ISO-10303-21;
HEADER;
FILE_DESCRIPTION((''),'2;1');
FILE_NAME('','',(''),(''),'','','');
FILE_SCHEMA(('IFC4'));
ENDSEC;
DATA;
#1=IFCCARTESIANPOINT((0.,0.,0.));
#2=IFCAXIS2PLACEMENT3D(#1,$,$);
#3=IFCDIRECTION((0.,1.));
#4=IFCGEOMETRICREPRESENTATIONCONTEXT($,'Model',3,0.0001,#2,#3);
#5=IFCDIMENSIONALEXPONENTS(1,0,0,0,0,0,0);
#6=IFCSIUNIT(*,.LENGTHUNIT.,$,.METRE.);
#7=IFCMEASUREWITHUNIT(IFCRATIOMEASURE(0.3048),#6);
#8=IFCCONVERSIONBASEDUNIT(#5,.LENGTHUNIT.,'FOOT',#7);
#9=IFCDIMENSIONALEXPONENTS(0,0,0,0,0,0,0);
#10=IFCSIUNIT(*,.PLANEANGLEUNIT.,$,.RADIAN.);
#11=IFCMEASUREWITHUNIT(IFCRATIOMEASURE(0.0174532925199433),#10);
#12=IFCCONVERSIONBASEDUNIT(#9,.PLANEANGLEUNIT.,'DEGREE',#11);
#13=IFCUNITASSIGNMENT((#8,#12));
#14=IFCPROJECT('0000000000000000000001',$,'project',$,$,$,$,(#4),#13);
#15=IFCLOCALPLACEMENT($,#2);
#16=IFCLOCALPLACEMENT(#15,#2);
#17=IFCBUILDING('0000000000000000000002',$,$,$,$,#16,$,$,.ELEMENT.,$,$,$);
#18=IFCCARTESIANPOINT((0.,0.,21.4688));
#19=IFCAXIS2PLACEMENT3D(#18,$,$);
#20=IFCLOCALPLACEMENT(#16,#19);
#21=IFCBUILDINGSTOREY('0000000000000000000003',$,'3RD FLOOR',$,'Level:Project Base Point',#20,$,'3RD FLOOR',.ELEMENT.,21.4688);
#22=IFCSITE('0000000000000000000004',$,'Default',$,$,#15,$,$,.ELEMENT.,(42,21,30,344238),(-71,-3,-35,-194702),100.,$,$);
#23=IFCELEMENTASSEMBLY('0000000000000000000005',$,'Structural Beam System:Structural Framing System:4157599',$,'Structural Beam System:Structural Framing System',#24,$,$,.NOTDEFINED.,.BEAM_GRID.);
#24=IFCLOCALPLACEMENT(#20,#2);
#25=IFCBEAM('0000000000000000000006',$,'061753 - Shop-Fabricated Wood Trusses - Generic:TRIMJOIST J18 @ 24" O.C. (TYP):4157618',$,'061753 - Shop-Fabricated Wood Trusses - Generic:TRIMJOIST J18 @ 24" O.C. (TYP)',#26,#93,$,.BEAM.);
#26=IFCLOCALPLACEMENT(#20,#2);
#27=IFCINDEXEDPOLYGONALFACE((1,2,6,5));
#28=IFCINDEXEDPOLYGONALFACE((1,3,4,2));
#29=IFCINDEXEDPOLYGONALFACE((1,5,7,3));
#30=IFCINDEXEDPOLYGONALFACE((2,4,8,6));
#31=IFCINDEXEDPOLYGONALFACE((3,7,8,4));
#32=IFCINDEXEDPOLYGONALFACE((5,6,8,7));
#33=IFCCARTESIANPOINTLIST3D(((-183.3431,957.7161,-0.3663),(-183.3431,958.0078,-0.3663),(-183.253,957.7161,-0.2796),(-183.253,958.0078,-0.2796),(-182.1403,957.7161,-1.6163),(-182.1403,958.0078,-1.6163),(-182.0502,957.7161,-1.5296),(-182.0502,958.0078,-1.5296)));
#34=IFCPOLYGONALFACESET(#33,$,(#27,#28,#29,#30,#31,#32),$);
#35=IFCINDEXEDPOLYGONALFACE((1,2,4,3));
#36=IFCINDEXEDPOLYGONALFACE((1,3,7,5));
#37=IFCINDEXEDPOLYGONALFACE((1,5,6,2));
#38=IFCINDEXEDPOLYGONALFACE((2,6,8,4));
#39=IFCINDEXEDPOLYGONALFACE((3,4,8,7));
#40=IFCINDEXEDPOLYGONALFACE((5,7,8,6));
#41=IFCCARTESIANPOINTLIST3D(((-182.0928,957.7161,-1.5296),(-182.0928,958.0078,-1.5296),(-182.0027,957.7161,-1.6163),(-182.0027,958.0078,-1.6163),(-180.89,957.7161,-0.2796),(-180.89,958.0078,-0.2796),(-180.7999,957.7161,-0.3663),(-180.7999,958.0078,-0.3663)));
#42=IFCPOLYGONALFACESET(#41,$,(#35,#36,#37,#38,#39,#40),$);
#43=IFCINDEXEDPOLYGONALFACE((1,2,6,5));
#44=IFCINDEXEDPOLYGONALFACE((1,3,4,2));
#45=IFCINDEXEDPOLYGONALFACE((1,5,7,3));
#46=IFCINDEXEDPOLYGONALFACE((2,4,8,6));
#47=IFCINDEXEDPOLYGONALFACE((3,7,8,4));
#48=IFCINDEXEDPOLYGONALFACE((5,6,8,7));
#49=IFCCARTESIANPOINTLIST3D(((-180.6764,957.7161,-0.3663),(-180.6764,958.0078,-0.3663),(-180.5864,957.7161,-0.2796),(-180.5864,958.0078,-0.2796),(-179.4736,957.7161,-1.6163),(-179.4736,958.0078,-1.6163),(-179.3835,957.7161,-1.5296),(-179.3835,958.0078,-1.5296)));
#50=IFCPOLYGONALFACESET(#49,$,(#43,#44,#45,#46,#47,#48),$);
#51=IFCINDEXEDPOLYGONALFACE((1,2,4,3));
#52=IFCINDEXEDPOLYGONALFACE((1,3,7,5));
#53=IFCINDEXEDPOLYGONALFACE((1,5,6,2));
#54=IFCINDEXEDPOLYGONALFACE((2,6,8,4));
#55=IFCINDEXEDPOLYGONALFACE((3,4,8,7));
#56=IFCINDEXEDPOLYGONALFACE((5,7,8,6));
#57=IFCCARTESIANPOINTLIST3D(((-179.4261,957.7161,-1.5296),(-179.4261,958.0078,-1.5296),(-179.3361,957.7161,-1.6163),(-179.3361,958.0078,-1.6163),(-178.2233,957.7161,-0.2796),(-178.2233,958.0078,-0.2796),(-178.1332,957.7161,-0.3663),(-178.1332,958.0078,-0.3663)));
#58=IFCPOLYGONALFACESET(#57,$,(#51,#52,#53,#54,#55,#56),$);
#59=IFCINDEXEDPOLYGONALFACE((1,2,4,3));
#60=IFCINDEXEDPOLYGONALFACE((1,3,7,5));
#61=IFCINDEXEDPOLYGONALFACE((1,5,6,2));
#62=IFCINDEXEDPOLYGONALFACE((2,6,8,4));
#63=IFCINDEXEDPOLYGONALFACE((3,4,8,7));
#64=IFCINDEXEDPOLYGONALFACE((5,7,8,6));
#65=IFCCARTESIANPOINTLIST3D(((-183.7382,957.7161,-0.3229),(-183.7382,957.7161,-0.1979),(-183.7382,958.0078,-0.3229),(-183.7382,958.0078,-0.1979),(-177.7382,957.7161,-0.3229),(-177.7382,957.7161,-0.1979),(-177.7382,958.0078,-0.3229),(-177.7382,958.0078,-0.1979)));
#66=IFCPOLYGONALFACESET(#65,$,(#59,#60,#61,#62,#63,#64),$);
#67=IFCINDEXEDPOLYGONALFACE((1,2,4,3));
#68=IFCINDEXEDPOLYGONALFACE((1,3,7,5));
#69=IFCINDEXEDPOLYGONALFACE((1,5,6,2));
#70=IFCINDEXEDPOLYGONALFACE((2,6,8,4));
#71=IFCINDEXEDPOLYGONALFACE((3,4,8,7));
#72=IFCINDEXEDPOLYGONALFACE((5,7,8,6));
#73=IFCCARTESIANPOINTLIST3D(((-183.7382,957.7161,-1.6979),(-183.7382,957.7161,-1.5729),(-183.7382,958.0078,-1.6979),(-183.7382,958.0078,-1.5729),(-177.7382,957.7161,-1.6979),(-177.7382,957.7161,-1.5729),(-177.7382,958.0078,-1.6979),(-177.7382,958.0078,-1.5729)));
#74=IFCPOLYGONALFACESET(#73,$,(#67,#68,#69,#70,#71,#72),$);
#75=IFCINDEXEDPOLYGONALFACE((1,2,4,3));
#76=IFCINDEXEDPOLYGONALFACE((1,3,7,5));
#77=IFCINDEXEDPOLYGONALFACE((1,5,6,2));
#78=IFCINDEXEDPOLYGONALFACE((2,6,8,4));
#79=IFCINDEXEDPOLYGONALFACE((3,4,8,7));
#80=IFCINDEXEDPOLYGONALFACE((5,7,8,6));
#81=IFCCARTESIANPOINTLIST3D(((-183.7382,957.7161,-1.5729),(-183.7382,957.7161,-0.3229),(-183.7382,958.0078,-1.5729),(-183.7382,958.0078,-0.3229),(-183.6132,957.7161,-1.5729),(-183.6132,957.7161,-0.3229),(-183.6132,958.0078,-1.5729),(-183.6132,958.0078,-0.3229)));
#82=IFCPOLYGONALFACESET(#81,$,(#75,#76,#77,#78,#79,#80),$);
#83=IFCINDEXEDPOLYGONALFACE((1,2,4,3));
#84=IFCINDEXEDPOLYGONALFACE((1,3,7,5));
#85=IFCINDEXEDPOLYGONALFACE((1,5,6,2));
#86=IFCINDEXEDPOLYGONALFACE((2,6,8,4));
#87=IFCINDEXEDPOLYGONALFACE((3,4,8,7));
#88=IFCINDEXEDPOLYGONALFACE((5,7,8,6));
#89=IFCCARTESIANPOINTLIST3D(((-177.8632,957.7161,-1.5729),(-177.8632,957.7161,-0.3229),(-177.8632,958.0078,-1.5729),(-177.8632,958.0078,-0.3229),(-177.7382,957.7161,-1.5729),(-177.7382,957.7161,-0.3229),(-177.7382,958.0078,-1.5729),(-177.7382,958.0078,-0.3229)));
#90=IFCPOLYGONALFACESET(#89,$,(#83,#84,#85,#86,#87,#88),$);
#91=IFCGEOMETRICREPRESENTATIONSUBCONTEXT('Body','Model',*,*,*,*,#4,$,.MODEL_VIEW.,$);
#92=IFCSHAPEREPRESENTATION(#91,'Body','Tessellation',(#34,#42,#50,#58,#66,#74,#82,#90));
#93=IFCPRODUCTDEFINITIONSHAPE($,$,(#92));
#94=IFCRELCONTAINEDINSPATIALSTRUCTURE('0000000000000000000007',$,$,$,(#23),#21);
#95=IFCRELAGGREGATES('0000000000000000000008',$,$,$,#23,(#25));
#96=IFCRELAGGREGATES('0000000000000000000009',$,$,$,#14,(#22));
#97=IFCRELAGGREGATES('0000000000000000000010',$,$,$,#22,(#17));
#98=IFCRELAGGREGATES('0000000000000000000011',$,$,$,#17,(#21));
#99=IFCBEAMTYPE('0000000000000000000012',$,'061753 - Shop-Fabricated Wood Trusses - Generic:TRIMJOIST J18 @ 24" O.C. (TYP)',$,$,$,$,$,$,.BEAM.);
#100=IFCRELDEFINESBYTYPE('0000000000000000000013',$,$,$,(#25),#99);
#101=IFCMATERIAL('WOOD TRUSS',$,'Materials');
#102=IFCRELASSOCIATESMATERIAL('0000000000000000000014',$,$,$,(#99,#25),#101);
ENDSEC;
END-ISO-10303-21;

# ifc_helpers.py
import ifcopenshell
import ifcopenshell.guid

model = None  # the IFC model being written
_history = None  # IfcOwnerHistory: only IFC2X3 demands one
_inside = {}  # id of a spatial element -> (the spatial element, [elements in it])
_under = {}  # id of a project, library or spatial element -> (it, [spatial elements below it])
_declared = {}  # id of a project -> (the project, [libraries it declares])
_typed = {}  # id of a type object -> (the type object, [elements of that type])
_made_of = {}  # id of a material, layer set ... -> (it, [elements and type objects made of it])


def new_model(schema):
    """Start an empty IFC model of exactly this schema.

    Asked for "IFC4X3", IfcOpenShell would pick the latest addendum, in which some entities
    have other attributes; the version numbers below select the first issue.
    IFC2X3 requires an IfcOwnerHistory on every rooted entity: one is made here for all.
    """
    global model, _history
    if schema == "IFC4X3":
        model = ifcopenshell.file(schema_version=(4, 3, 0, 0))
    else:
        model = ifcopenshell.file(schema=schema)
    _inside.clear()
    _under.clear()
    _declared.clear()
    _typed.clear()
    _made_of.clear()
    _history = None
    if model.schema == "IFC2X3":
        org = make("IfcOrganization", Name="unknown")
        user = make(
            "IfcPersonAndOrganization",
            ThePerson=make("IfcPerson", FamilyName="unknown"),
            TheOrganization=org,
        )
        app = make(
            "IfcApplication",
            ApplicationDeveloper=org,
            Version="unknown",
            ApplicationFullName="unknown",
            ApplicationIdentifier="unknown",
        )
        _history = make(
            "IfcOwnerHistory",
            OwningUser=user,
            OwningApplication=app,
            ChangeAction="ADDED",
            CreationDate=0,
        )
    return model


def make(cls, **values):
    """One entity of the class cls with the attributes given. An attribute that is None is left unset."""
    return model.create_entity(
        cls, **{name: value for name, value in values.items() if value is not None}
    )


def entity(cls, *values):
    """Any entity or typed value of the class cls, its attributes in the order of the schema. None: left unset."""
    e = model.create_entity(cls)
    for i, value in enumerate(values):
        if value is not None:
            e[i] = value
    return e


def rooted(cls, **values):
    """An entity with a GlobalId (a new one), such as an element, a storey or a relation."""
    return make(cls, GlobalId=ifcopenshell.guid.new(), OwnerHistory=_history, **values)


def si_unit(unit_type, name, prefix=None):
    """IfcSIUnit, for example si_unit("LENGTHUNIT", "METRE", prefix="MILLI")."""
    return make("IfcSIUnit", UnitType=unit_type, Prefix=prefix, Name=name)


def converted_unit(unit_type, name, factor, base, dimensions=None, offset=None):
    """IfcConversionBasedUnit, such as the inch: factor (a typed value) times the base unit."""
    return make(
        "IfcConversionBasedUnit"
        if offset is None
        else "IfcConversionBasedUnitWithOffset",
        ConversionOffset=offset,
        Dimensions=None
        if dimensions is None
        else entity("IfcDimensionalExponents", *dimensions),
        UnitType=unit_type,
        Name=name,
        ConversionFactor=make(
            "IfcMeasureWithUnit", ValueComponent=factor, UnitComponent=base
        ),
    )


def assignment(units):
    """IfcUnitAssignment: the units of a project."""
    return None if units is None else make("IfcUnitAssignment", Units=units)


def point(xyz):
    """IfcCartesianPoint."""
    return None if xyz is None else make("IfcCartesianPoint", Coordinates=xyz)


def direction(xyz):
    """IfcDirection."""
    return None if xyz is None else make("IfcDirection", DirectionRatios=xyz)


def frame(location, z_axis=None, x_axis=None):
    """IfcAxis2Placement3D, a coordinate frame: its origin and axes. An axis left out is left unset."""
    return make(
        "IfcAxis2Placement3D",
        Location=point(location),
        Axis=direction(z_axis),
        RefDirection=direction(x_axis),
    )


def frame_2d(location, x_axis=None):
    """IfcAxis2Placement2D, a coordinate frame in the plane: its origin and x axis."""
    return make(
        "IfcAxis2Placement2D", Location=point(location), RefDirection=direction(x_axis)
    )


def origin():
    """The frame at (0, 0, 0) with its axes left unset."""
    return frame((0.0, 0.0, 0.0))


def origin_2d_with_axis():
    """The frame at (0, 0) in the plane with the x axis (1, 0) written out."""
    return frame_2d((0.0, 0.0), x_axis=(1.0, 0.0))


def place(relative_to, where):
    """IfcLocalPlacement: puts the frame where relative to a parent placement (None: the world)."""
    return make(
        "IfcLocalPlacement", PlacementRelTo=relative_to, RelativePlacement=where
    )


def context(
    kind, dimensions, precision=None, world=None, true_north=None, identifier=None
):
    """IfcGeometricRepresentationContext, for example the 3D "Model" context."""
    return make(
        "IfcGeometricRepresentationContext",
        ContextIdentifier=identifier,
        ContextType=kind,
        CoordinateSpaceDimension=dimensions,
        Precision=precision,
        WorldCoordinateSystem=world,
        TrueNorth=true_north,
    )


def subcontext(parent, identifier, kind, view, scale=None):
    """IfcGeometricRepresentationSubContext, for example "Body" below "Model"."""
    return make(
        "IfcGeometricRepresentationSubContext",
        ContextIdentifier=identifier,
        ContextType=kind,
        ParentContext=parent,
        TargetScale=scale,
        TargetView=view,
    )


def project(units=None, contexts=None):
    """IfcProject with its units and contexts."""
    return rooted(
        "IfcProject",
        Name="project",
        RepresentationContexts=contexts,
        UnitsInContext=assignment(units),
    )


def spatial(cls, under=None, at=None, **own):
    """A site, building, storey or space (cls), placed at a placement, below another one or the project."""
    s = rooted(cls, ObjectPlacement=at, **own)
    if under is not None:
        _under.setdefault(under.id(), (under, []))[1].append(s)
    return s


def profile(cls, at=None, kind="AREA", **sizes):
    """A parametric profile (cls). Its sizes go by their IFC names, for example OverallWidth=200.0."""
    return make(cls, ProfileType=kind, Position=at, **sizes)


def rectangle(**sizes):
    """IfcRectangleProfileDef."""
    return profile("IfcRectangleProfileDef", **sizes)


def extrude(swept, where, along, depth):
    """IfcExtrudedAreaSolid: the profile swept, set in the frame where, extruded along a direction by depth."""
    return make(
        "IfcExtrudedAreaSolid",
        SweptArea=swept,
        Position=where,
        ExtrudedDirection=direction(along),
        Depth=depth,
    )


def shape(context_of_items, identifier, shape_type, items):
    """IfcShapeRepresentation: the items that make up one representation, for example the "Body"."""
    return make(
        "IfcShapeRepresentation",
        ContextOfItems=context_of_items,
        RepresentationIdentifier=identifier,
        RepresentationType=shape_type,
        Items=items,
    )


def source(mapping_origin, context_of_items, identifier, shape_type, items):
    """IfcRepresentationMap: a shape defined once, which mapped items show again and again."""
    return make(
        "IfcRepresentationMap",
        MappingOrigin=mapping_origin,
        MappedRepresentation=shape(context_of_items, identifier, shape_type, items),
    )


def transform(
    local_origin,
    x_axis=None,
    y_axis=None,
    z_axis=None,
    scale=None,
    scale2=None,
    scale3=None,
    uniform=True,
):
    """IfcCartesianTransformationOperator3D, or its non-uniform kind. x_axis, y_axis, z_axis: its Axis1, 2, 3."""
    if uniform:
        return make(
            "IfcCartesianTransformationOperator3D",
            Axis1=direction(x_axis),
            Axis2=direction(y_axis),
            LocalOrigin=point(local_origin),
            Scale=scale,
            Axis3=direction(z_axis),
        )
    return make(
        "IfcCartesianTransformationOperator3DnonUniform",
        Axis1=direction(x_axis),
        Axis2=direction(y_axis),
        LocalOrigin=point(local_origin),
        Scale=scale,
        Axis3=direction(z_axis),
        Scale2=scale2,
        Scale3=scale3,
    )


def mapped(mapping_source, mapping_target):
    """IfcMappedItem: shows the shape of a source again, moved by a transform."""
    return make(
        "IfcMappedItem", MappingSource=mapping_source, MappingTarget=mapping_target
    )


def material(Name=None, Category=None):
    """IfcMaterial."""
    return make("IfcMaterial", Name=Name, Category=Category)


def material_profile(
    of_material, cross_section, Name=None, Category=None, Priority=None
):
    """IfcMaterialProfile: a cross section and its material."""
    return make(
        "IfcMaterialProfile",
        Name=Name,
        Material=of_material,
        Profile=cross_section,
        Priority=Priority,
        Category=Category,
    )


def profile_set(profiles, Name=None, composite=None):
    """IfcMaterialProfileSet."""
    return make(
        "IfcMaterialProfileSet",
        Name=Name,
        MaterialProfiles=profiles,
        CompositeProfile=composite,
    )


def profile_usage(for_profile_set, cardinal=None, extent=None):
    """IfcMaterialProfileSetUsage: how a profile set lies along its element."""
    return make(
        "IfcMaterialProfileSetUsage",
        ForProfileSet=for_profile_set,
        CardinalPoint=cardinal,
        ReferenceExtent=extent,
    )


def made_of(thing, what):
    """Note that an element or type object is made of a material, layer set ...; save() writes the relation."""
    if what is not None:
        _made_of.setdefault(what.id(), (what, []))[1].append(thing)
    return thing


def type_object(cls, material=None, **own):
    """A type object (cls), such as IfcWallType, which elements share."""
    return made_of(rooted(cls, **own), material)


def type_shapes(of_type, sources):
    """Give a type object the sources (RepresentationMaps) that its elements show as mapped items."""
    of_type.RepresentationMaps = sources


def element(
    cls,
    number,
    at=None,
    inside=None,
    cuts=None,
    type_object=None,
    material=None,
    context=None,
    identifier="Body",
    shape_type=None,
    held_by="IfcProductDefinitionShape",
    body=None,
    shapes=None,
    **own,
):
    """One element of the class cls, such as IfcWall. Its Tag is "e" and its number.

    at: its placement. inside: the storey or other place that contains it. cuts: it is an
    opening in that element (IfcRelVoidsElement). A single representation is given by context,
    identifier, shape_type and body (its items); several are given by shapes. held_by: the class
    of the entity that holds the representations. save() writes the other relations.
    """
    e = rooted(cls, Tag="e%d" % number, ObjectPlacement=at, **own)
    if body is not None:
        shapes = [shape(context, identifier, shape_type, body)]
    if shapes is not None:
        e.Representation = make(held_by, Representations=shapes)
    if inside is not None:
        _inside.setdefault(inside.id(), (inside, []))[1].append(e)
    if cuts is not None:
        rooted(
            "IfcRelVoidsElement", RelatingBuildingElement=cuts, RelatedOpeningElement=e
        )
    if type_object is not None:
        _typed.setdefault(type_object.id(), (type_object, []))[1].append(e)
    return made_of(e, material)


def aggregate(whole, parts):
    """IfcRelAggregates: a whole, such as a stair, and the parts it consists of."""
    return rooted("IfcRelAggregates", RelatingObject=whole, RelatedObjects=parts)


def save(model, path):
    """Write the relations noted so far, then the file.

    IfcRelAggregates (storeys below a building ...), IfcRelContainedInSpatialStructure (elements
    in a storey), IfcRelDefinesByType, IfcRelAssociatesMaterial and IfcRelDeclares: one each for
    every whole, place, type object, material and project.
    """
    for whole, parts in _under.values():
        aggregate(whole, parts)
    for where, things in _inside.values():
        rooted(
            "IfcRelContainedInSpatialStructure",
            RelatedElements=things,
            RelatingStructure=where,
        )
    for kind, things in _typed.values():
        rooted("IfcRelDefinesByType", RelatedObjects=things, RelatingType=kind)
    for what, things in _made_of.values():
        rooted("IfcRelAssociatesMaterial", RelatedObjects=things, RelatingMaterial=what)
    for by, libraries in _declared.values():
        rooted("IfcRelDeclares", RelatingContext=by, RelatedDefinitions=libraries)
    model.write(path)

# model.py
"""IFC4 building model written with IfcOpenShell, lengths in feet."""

from ifc_helpers import new_model, entity, si_unit, converted_unit, direction, frame, frame_2d, origin, origin_2d_with_axis, place, context, subcontext, project, spatial, rectangle, extrude, source, transform, mapped, material, material_profile, profile_set, profile_usage, type_object, type_shapes, element, aggregate, save


model = new_model("IFC4")

# Units and contexts
model_context = context("Model", 3, precision=0.0001, world=origin(), true_north=direction((0.0, 1.0)))
body_context = subcontext(model_context, "Body", "Model", "MODEL_VIEW")
ifc_project = project(units=[converted_unit("LENGTHUNIT", "FOOT", entity("IfcRatioMeasure", 0.3048), si_unit("LENGTHUNIT", "METRE"), dimensions=[1, 0, 0, 0, 0, 0, 0]), converted_unit("PLANEANGLEUNIT", "DEGREE", entity("IfcRatioMeasure", 0.0174532925199433), si_unit("PLANEANGLEUNIT", "RADIAN"), dimensions=[0, 0, 0, 0, 0, 0, 0])], contexts=[model_context])

# Site, building, storey
site_placement = place(None, origin())
site = spatial("IfcSite", under=ifc_project, at=site_placement, Name="Default", CompositionType="ELEMENT", RefLatitude=(42, 21, 30, 344238), RefLongitude=(-71, -3, -35, -194702), RefElevation=100.0)
building_placement = place(site_placement, origin())
building = spatial("IfcBuilding", under=site, at=building_placement, CompositionType="ELEMENT")
storey_placement = place(building_placement, frame((0.0, 0.0, 21.4688)))
storey = spatial("IfcBuildingStorey", under=building, at=storey_placement, Name="3RD FLOOR", ObjectType="Level:Project Base Point", LongName="3RD FLOOR", CompositionType="ELEMENT", Elevation=21.4688)

# Element assembly, beam
assembly_1_placement = place(storey_placement, origin())
assembly_1 = element("IfcElementAssembly", 1, at=assembly_1_placement, inside=storey, Name="Structural Beam System:Structural Framing System:4157599", ObjectType="Structural Beam System:Structural Framing System", AssemblyPlace="NOTDEFINED", PredefinedType="BEAM_GRID")
ifc_material_1 = material(Name="WOOD TRUSS", Category="Materials")
ifc_material_profile_1 = material_profile(ifc_material_1, rectangle(XDim=1.7347, YDim=0.125, at=frame_2d((0.0, 0.0), x_axis=(1.0, 0.0))), Name="TRIMJOIST J18 @ 24\" O.C. (TYP)")
ifc_material_profile_2 = material_profile(ifc_material_1, rectangle(XDim=1.7347, YDim=0.125, at=frame_2d((0.0, 0.0), x_axis=(1.0, 0.0))), Name="TRIMJOIST J18 @ 24\" O.C. (TYP)")
ifc_material_profile_3 = material_profile(ifc_material_1, rectangle(XDim=1.7347, YDim=0.125, at=frame_2d((0.0, 0.0), x_axis=(1.0, 0.0))), Name="TRIMJOIST J18 @ 24\" O.C. (TYP)")
ifc_material_profile_4 = material_profile(ifc_material_1, rectangle(XDim=1.7347, YDim=0.125, at=frame_2d((0.0, 0.0), x_axis=(1.0, 0.0))), Name="TRIMJOIST J18 @ 24\" O.C. (TYP)")
ifc_material_profile_5 = material_profile(ifc_material_1, rectangle(XDim=1.7347, YDim=0.125, at=frame_2d((0.0, 0.0), x_axis=(1.0, 0.0))), Name="TRIMJOIST J18 @ 24\" O.C. (TYP)")
ifc_material_profile_6 = material_profile(ifc_material_1, rectangle(XDim=1.7347, YDim=0.125, at=frame_2d((0.0, 0.0), x_axis=(1.0, 0.0))), Name="TRIMJOIST J18 @ 24\" O.C. (TYP)")
ifc_material_profile_7 = material_profile(ifc_material_1, rectangle(XDim=1.7347, YDim=0.125, at=frame_2d((0.0, 0.0), x_axis=(1.0, 0.0))), Name="TRIMJOIST J18 @ 24\" O.C. (TYP)")
ifc_material_profile_8 = material_profile(ifc_material_1, rectangle(XDim=1.7347, YDim=0.125, at=frame_2d((0.0, 0.0), x_axis=(1.0, 0.0))), Name="TRIMJOIST J18 @ 24\" O.C. (TYP)")
ifc_material_profile_9 = material_profile(ifc_material_1, rectangle(XDim=1.7347, YDim=0.125, at=frame_2d((0.0, 0.0), x_axis=(1.0, 0.0))), Name="TRIMJOIST J18 @ 24\" O.C. (TYP)")
ifc_material_profile_10 = material_profile(ifc_material_1, rectangle(XDim=1.7347, YDim=0.125, at=origin_2d_with_axis()), Name="TRIMJOIST J18 @ 24\" O.C. (TYP)")
ifc_material_profile_11 = material_profile(ifc_material_1, rectangle(XDim=0.125, YDim=0.2917, at=origin_2d_with_axis()), Name="TRIMJOIST J18 @ 24\" O.C. (TYP)")
ifc_material_profile_12 = material_profile(ifc_material_1, rectangle(XDim=0.125, YDim=0.2917, at=origin_2d_with_axis()), Name="TRIMJOIST J18 @ 24\" O.C. (TYP)")
ifc_material_profile_13 = material_profile(ifc_material_1, rectangle(XDim=1.25, YDim=0.2917, at=origin_2d_with_axis()), Name="TRIMJOIST J18 @ 24\" O.C. (TYP)")
ifc_material_profile_14 = material_profile(ifc_material_1, rectangle(XDim=1.25, YDim=0.2917, at=origin_2d_with_axis()), Name="TRIMJOIST J18 @ 24\" O.C. (TYP)")
ifc_profile_set_1 = profile_set([ifc_material_profile_1, ifc_material_profile_2, ifc_material_profile_3, ifc_material_profile_4, ifc_material_profile_5, ifc_material_profile_6, ifc_material_profile_7, ifc_material_profile_8, ifc_material_profile_9, ifc_material_profile_10, ifc_material_profile_11, ifc_material_profile_12, ifc_material_profile_13, ifc_material_profile_14], Name="TRIMJOIST J18 @ 24\" O.C. (TYP)")
ifc_profile_usage_1 = profile_usage(ifc_profile_set_1, cardinal=8)
beam_type_1 = type_object("IfcBeamType", Name="061753 - Shop-Fabricated Wood Trusses - Generic:TRIMJOIST J18 @ 24\" O.C. (TYP)", PredefinedType="BEAM", material=ifc_profile_set_1)
shared_shape_1 = source(origin(), body_context, "Body", "SweptSolid", [
    extrude(rectangle(XDim=1.7347, YDim=0.125, at=frame_2d((0.0, 0.0), x_axis=(1.0, 0.0))), frame((1.9585, -0.1458, 0.0), z_axis=(0.0, 1.0, 0.0), x_axis=(0.693383, 0.0, 0.720569)), (0.0, 0.0, 1.0), 0.2917),
    extrude(rectangle(XDim=1.7347, YDim=0.125, at=frame_2d((0.0, 0.0), x_axis=(1.0, 0.0))), frame((0.7082, -0.1458, 0.0), z_axis=(0.0, 1.0, 0.0), x_axis=(0.693383, 0.0, -0.720569)), (0.0, 0.0, 1.0), 0.2917),
    extrude(rectangle(XDim=1.7347, YDim=0.125, at=frame_2d((0.0, 0.0), x_axis=(1.0, 0.0))), frame((-0.7082, -0.1458, 0.0), z_axis=(0.0, 1.0, 0.0), x_axis=(0.693383, 0.0, 0.720569)), (0.0, 0.0, 1.0), 0.2917),
    extrude(rectangle(XDim=1.7347, YDim=0.125, at=frame_2d((0.0, 0.0), x_axis=(1.0, 0.0))), frame((-1.9585, -0.1458, 0.0), z_axis=(0.0, 1.0, 0.0), x_axis=(0.693383, 0.0, -0.720569)), (0.0, 0.0, 1.0), 0.2917),
    extrude(rectangle(XDim=0.125, YDim=0.2917, at=origin_2d_with_axis()), frame((-3.0, 0.0, 0.6875), z_axis=(1.0, 0.0, 0.0), x_axis=(0.0, 0.0, -1.0)), (0.0, 0.0, 1.0), 6.0),
    extrude(rectangle(XDim=0.125, YDim=0.2917, at=origin_2d_with_axis()), frame((-3.0, 0.0, -0.6875), z_axis=(1.0, 0.0, 0.0), x_axis=(0.0, 0.0, -1.0)), (0.0, 0.0, 1.0), 6.0),
    extrude(rectangle(XDim=1.25, YDim=0.2917, at=origin_2d_with_axis()), frame((2.875, 0.0, 0.0), z_axis=(1.0, 0.0, 0.0), x_axis=(0.0, 0.0, -1.0)), (0.0, 0.0, 1.0), 0.125),
    extrude(rectangle(XDim=1.25, YDim=0.2917, at=origin_2d_with_axis()), frame((-3.0, 0.0, 0.0), z_axis=(1.0, 0.0, 0.0), x_axis=(0.0, 0.0, -1.0)), (0.0, 0.0, 1.0), 0.125),
])
type_shapes(beam_type_1, [shared_shape_1])
beam_1_placement = place(assembly_1_placement, frame((-180.7382, 957.8619, -0.9479), z_axis=(0.0, 0.0, 1.0), x_axis=(-1.0, 0.0, 0.0)))
beam_1 = element("IfcBeam", 2, at=beam_1_placement, type_object=beam_type_1, material=ifc_profile_usage_1, Name="061753 - Shop-Fabricated Wood Trusses - Generic:TRIMJOIST J18 @ 24\" O.C. (TYP):4157618", ObjectType="061753 - Shop-Fabricated Wood Trusses - Generic:TRIMJOIST J18 @ 24\" O.C. (TYP)", PredefinedType="BEAM", context=body_context, shape_type="MappedRepresentation", body=[
    mapped(shared_shape_1, transform((0.0, 0.0, 0.0), scale=1.0)),
])
aggregate(assembly_1, [beam_1])

save(model, "model.ifc")
